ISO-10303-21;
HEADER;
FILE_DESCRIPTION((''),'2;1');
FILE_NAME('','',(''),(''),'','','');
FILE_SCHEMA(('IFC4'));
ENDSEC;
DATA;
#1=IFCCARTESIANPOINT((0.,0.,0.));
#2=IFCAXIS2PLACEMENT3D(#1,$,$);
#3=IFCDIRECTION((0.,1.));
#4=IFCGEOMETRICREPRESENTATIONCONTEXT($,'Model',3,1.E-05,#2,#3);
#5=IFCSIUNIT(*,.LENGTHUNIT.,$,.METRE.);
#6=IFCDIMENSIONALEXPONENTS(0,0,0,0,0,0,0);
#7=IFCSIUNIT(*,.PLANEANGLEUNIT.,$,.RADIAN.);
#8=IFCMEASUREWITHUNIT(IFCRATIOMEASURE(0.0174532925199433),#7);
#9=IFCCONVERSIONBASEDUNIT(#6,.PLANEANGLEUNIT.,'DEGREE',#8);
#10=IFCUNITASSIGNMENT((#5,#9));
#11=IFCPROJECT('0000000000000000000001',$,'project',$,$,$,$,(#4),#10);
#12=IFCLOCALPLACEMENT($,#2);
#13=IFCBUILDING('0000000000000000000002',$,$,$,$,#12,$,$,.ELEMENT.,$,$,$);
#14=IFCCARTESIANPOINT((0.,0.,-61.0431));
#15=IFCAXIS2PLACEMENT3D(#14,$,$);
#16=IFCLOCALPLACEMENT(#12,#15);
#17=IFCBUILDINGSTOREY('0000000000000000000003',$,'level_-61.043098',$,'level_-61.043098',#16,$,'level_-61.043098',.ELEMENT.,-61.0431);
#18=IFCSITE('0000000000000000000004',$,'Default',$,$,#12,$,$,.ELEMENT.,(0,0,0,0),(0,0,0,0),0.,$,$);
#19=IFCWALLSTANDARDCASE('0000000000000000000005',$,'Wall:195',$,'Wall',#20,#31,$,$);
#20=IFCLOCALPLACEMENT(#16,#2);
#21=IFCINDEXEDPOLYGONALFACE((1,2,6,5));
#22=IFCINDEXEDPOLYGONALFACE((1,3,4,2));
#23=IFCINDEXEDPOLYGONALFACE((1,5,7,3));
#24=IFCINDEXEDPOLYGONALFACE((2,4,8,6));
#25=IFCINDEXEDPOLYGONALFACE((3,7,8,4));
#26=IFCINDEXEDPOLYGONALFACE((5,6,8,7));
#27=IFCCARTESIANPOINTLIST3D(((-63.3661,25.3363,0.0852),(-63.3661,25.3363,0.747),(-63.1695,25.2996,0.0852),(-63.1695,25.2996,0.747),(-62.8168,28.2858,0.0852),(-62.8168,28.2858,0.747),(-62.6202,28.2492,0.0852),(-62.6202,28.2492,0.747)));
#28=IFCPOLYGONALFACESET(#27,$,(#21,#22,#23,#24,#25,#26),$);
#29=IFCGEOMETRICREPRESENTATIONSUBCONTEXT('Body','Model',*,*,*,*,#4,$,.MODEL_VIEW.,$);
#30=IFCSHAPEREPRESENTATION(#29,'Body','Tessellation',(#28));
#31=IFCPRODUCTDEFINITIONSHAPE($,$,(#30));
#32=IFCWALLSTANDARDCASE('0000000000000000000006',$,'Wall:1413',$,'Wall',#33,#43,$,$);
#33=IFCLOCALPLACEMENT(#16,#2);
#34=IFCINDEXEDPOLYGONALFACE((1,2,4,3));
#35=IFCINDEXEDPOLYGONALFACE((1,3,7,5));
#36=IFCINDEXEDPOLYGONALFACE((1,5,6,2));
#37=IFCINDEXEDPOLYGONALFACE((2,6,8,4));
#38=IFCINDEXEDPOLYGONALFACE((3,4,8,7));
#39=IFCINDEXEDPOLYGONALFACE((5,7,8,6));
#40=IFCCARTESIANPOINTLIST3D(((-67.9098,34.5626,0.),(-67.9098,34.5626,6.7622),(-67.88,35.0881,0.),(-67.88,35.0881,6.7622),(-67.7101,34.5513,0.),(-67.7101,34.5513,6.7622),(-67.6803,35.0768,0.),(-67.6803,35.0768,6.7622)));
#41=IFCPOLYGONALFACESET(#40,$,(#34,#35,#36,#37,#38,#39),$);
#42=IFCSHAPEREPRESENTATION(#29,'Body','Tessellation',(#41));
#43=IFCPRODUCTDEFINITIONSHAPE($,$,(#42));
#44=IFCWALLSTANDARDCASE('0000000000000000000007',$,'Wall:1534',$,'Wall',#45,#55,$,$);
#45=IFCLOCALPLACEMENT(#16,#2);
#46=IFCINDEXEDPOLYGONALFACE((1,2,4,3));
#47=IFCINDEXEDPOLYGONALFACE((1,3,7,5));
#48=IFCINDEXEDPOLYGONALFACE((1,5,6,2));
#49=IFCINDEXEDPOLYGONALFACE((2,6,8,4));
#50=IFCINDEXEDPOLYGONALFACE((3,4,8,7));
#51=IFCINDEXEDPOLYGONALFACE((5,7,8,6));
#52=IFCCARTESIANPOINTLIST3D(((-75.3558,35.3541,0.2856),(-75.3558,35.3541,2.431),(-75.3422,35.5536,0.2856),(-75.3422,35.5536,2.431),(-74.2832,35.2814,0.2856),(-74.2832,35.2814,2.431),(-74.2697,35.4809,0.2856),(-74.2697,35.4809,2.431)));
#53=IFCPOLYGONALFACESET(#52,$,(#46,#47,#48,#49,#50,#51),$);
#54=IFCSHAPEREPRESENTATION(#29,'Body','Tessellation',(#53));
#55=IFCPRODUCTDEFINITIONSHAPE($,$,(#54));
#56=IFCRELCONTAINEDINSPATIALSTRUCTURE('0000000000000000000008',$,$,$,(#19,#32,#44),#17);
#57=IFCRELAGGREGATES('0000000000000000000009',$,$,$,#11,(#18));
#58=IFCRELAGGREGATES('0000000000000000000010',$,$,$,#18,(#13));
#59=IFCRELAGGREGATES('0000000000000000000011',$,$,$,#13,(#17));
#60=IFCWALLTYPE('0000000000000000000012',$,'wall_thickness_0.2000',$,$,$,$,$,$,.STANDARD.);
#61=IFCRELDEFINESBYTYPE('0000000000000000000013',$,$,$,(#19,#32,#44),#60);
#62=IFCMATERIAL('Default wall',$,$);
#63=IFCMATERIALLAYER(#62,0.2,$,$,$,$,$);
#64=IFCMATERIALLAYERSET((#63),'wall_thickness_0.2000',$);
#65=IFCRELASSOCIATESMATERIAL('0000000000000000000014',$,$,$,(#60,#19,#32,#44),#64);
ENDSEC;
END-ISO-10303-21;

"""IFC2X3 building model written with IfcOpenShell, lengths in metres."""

from ifc_helpers import new_model, entity, si_unit, converted_unit, direction, frame, origin, place, context, subcontext, project, spatial, polyline, outline, extrude, material, layer, layer_set, layer_usage, type_object, element, save


model = new_model("IFC2X3")

# Units and contexts
model_context = context("Model", 3, precision=1e-05, world=origin(), true_north=direction((0.0, 1.0)))
body_context = subcontext(model_context, "Body", "Model", "MODEL_VIEW")
ifc_project = project(units=[si_unit("LENGTHUNIT", "METRE"), converted_unit("PLANEANGLEUNIT", "DEGREE", entity("IfcRatioMeasure", 0.0174532925199433), si_unit("PLANEANGLEUNIT", "RADIAN"), dimensions=[0, 0, 0, 0, 0, 0, 0])], contexts=[model_context])

# Site, building, storey
placement_1 = place(None, origin())
site = spatial("IfcSite", under=ifc_project, at=placement_1, Name="Default", CompositionType="ELEMENT", RefLatitude=(0, 0, 0, 0), RefLongitude=(0, 0, 0, 0), RefElevation=0.0)
building = spatial("IfcBuilding", under=site, at=placement_1, CompositionType="ELEMENT")
storey_placement = place(placement_1, frame((0.0, 0.0, -61.0431)))
storey = spatial("IfcBuildingStorey", under=building, at=storey_placement, Name="level_-61.043098", ObjectType="level_-61.043098", LongName="level_-61.043098", CompositionType="ELEMENT", Elevation=-61.0431)

# Wall
ifc_material_1 = material(Name="Default wall")
ifc_layer = layer(ifc_material_1, 0.2)
ifc_layer_set = layer_set([ifc_layer], Name="wall_thickness_0.2000")
ifc_layer_usage = layer_usage(ifc_layer_set, "AXIS2", "POSITIVE", -0.1)
wall_type = type_object("IfcWallType", Name="wall_thickness_0.2000", PredefinedType="STANDARD", material=ifc_layer_set)
placement_2 = place(placement_1, frame((0.0, 0.0, -60.9579)))
wall_1_placement = place(placement_2, frame((-63.2678, 25.3179, 0.0), z_axis=(0.0, 0.0, 1.0), x_axis=(0.183105, 0.983093, 0.0)))
element("IfcWallStandardCase", 1, at=wall_1_placement, inside=storey, type_object=wall_type, material=ifc_layer_usage, Name="Wall:195", ObjectType="Wall", context=body_context, shape_type="SweptSolid", body=[
    extrude(outline(polyline([(3.0003, -0.1), (3.0003, 0.1), (0.0, 0.1), (0.0, -0.1), (3.0003, -0.1)])), origin(), (0.0, 0.0, 1.0), 0.6618),
])

# Walls
wall_2_placement = place(storey_placement, frame((-67.8099, 34.557, 0.0), z_axis=(0.0, 0.0, 1.0), x_axis=(0.056608, 0.998396, 0.0)))
element("IfcWallStandardCase", 2, at=wall_2_placement, inside=storey, type_object=wall_type, material=ifc_layer_usage, Name="Wall:1413", ObjectType="Wall", context=body_context, shape_type="SweptSolid", body=[
    extrude(outline(polyline([(0.5263, -0.1), (0.5263, 0.1), (0.0, 0.1), (0.0, -0.1), (0.5263, -0.1)])), origin(), (0.0, 0.0, 1.0), 6.7622),
])
placement_3 = place(placement_1, frame((0.0, 0.0, -60.7575)))
wall_3_placement = place(placement_3, frame((-74.2765, 35.3812, 0.0), z_axis=(0.0, 0.0, 1.0), x_axis=(-0.997713, 0.067596, 0.0)))
element("IfcWallStandardCase", 3, at=wall_3_placement, inside=storey, type_object=wall_type, material=ifc_layer_usage, Name="Wall:1534", ObjectType="Wall", context=body_context, shape_type="SweptSolid", body=[
    extrude(outline(polyline([(1.075, -0.1), (1.075, 0.1), (0.0, 0.1), (0.0, -0.1), (1.075, -0.1)])), origin(), (0.0, 0.0, 1.0), 2.1454),
])

save(model, "model.ifc")
